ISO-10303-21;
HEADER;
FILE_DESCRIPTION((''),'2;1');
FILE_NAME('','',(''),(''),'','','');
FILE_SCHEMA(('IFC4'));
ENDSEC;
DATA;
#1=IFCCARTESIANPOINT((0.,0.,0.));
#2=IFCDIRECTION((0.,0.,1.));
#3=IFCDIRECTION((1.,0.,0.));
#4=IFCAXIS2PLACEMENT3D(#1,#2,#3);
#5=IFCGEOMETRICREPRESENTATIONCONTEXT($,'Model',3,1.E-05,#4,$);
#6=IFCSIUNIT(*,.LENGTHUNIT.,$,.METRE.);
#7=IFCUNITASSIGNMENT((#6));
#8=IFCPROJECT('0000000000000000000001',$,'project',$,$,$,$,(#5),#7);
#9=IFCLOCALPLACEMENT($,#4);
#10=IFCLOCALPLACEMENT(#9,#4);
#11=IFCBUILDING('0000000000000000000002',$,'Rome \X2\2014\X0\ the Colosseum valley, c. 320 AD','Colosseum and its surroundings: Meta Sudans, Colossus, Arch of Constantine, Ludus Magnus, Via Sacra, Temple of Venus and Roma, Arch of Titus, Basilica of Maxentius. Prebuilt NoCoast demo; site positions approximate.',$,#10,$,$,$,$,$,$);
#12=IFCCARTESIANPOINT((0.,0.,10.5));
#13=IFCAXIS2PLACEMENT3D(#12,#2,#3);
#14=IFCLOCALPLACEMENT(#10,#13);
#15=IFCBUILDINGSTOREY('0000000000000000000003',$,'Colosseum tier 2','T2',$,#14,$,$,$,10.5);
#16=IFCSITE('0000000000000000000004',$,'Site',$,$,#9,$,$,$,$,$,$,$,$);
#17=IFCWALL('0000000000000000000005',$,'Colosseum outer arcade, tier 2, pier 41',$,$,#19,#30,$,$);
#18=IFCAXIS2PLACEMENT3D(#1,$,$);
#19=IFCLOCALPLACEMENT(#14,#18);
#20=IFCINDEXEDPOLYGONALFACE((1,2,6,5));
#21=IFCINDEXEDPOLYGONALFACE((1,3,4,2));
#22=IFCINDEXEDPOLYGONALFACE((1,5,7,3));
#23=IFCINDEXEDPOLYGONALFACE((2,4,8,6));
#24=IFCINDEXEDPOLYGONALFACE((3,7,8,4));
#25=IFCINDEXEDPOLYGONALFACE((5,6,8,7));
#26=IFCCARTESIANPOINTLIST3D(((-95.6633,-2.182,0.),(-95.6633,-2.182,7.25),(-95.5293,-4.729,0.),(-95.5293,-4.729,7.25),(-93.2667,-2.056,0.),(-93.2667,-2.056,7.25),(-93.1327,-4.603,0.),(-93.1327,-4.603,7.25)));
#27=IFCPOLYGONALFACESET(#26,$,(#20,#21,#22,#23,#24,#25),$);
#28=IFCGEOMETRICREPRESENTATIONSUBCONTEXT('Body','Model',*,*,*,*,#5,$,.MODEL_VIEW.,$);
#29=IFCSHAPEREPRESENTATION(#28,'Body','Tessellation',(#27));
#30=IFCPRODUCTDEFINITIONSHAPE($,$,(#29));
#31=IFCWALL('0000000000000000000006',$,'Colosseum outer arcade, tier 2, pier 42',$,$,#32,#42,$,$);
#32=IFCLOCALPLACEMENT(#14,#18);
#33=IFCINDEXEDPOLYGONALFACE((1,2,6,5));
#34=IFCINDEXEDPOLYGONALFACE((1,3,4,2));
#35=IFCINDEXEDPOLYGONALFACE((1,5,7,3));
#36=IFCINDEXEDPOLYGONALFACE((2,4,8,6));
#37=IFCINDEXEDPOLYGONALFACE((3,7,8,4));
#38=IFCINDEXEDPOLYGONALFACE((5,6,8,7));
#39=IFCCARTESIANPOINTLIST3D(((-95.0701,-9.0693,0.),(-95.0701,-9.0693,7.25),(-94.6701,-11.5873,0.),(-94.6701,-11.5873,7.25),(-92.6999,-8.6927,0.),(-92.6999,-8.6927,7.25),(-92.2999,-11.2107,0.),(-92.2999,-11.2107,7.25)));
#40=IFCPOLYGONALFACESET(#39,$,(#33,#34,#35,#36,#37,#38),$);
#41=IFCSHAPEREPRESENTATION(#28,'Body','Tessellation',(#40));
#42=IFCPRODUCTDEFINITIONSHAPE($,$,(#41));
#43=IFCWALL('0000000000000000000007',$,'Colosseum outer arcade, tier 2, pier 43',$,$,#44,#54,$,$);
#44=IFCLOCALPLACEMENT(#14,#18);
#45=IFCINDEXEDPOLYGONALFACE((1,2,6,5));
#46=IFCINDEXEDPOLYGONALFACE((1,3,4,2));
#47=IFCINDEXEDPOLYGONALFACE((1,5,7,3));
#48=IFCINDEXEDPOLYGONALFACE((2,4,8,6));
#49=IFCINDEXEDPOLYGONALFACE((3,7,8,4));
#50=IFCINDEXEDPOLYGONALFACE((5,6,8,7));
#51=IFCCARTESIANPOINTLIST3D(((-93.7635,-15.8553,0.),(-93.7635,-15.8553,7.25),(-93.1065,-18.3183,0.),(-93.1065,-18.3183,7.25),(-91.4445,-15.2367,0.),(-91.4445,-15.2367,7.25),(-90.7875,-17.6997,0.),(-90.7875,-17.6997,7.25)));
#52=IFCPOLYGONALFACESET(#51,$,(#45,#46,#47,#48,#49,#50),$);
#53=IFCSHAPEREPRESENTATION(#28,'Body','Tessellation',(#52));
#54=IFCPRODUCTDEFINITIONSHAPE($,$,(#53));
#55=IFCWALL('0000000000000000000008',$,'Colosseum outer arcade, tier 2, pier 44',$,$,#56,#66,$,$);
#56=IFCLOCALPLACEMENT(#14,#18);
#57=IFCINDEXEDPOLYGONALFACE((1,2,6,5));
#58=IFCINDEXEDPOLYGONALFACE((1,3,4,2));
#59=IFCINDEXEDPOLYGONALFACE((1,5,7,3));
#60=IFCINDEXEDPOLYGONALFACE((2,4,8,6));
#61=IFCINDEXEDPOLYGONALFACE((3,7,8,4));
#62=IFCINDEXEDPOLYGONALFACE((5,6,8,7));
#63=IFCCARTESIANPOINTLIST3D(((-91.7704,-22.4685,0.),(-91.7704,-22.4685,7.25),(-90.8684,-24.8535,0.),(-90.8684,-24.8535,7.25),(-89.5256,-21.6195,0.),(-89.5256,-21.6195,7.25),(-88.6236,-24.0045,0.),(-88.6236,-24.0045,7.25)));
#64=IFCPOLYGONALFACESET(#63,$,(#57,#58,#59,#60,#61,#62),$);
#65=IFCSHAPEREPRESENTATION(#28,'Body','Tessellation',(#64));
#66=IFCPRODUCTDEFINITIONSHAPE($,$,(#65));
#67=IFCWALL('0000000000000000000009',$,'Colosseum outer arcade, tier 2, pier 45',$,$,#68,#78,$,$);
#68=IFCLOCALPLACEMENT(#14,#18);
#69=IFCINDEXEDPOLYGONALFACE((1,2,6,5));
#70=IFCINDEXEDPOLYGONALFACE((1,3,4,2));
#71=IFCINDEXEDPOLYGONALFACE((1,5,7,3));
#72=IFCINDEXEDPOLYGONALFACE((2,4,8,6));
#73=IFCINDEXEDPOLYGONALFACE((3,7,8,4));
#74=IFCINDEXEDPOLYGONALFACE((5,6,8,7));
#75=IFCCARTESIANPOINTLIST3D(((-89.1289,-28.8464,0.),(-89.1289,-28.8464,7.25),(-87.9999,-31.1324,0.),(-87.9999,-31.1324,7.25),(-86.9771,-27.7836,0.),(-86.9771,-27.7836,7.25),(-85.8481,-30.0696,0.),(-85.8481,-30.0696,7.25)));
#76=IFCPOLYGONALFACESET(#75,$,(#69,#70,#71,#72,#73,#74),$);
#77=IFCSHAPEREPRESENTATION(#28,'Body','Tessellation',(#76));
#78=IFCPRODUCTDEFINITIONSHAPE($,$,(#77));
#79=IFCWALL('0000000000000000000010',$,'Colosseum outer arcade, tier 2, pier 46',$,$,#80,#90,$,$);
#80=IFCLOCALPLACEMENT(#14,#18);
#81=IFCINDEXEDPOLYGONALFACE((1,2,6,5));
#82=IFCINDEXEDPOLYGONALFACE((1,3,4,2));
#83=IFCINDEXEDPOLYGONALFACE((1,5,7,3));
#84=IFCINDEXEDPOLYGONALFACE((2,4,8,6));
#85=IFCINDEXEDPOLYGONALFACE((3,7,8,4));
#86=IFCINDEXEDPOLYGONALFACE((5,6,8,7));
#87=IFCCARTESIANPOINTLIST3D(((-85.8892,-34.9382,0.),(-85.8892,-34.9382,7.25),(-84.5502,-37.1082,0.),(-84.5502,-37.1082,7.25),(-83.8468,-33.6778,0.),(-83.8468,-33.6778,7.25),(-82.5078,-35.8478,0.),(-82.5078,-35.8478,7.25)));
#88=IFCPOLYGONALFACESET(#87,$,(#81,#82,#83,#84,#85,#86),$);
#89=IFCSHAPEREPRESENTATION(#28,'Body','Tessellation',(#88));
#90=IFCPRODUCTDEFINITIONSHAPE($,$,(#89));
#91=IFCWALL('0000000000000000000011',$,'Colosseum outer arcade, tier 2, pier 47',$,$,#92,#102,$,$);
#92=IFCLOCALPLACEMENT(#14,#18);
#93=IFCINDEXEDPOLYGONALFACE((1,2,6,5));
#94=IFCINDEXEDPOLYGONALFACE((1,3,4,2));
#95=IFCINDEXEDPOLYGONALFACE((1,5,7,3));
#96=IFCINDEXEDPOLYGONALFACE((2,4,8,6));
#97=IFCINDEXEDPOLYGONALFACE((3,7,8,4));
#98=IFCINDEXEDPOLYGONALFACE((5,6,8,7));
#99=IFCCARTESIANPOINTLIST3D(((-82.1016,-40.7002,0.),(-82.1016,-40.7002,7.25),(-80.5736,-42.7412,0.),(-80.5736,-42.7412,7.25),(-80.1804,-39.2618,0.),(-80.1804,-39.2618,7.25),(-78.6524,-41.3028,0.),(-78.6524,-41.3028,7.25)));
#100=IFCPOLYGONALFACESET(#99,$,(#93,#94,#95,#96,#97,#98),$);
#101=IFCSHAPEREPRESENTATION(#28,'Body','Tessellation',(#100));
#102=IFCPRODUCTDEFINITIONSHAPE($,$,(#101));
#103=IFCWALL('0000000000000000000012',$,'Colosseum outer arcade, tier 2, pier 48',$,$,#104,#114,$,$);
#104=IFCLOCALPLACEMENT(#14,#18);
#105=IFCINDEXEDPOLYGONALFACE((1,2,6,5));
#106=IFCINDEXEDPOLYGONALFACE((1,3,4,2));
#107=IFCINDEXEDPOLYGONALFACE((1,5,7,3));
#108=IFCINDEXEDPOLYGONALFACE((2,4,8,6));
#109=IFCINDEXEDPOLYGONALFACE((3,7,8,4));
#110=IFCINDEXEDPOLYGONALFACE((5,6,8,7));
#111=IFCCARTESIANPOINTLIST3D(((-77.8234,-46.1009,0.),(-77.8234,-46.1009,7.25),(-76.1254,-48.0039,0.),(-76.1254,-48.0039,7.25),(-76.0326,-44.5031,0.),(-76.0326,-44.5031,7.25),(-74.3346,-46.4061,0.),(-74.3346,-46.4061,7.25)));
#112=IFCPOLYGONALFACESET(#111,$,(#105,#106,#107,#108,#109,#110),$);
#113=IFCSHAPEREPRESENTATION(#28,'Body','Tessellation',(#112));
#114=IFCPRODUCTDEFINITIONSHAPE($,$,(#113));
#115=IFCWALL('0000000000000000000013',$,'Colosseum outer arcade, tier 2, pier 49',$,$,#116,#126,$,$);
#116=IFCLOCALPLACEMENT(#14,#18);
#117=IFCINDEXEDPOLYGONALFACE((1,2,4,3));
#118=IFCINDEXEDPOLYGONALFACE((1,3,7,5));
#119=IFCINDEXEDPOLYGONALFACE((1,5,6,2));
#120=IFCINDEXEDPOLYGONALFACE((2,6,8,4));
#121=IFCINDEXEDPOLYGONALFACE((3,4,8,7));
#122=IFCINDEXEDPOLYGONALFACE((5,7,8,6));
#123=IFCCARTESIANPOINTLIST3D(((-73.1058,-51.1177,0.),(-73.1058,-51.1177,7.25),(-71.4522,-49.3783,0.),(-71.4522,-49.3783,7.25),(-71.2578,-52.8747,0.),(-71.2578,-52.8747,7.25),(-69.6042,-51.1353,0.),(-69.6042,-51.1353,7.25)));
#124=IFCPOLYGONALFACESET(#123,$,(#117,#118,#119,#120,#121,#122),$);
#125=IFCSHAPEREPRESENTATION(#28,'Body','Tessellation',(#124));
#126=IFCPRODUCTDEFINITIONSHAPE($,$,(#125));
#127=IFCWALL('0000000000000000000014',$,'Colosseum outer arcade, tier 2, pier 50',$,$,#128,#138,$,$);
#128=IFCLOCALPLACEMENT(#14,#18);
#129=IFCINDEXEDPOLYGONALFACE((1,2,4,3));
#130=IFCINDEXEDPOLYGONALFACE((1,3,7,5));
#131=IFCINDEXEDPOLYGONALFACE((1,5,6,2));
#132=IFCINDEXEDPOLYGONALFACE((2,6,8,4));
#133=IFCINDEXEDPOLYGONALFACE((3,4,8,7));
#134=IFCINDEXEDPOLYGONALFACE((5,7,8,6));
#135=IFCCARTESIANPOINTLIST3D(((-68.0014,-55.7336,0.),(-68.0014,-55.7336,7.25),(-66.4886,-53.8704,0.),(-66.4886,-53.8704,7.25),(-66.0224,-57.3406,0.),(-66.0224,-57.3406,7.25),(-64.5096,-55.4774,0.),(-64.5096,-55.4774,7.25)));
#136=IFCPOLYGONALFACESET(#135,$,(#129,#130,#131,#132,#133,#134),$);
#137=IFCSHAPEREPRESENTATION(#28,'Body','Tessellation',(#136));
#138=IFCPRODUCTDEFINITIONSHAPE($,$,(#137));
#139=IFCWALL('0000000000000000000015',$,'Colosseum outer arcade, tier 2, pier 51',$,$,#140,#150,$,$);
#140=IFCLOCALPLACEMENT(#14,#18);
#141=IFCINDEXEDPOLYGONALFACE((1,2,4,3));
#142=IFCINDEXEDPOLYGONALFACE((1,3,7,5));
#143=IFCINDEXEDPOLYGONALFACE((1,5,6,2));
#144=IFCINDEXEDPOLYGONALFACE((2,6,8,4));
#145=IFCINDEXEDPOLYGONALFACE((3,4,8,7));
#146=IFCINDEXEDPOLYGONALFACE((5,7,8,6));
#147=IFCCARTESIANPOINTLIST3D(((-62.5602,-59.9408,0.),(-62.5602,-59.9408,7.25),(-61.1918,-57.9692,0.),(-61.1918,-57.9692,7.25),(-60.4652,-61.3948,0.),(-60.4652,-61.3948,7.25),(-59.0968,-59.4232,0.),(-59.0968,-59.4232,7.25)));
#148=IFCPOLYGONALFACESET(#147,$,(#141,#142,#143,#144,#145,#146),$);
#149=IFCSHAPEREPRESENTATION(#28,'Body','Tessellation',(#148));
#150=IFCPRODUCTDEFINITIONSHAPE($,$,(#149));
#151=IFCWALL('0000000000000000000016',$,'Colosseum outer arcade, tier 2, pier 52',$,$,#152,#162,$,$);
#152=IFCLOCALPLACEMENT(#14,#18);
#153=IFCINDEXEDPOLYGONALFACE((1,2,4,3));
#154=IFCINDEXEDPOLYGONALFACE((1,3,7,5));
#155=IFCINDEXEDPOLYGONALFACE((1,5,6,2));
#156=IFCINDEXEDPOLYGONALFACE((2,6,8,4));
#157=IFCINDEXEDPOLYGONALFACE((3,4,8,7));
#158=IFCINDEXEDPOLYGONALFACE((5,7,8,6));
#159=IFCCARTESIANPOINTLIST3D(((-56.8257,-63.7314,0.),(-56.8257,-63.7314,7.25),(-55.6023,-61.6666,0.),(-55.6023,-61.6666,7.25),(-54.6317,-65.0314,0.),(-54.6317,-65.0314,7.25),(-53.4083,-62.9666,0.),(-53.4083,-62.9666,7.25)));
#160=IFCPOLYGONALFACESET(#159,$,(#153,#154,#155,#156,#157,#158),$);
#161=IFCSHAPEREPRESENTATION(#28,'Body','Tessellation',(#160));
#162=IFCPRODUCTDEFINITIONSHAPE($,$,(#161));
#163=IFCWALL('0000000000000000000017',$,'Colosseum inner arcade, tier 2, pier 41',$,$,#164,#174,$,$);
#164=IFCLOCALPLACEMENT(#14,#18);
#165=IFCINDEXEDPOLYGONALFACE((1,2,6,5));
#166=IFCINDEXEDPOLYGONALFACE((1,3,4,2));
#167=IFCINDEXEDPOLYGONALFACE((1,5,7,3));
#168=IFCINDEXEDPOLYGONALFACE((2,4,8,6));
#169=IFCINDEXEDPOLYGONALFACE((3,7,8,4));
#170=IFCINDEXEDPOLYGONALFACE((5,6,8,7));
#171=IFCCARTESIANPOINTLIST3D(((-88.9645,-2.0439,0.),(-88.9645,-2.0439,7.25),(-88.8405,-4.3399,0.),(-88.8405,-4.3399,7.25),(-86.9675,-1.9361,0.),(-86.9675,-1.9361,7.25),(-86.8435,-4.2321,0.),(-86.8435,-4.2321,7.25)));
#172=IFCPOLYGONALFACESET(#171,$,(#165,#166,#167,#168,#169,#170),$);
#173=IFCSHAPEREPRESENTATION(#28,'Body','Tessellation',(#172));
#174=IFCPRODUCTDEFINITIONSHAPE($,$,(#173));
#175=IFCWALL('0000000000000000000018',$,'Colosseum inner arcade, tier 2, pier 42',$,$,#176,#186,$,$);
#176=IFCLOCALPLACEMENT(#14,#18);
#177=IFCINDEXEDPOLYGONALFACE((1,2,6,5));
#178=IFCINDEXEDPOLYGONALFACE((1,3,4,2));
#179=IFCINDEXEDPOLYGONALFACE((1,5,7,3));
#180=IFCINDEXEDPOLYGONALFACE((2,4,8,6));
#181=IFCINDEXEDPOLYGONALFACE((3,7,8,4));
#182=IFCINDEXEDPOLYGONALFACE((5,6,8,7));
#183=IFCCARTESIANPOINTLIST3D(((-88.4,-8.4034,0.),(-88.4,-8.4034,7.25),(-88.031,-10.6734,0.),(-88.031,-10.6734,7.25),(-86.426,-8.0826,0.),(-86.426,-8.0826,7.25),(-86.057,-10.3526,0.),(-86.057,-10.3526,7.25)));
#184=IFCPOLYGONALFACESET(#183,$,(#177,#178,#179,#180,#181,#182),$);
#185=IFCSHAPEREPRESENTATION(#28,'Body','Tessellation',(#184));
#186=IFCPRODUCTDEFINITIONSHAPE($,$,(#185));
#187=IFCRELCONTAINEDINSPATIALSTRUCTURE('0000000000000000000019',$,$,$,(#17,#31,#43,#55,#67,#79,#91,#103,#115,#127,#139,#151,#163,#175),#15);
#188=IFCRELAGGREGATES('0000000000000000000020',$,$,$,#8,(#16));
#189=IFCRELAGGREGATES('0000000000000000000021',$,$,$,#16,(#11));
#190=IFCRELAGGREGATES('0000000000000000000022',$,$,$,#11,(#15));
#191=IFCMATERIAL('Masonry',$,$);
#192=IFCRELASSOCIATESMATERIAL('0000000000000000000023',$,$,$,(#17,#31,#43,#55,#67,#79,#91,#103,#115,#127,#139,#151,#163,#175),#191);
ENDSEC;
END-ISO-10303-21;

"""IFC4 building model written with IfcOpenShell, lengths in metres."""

from ifc_helpers import new_model, si_unit, frame, origin_with_axes, place, context, subcontext, project, spatial, indexed_curve, outline, extrude, material, element, save


model = new_model("IFC4")

# Units and contexts
model_context = context("Model", 3, precision=1e-05, world=origin_with_axes())
body_context = subcontext(model_context, "Body", "Model", "MODEL_VIEW")
ifc_project = project(units=[si_unit("LENGTHUNIT", "METRE")], contexts=[model_context])

# Site, building, storey
site_placement = place(None, origin_with_axes())
site = spatial("IfcSite", under=ifc_project, at=site_placement, Name="Site")
building_placement = place(site_placement, origin_with_axes())
building = spatial("IfcBuilding", under=site, at=building_placement, Name="Rome — the Colosseum valley, c. 320 AD", Description="Colosseum and its surroundings: Meta Sudans, Colossus, Arch of Constantine, Ludus Magnus, Via Sacra, Temple of Venus and Roma, Arch of Titus, Basilica of Maxentius. Prebuilt NoCoast demo; site positions approximate.")
storey_placement = place(building_placement, frame((0.0, 0.0, 10.5), z_axis=(0.0, 0.0, 1.0), x_axis=(1.0, 0.0, 0.0)))
storey = spatial("IfcBuildingStorey", under=building, at=storey_placement, Name="Colosseum tier 2", Description="T2", Elevation=10.5)

# Walls
ifc_material = material(Name="Masonry")
wall_1_placement = place(storey_placement, frame((-94.465, -2.119, 0.0), z_axis=(0.0, 0.0, 1.0), x_axis=(0.052538, -0.998619, 0.0)))
element("IfcWall", 1, at=wall_1_placement, inside=storey, material=ifc_material, Name="Colosseum outer arcade, tier 2, pier 41", context=body_context, shape_type="SweptSolid", body=[
    extrude(outline(indexed_curve([(0.0, 0.0), (0.0, 2.4), (2.5505, 2.4), (2.5505, 0.0), (0.0, 0.0)], self_intersect=False)), frame((0.0, -1.2, 0.0), z_axis=(0.0, 0.0, 1.0), x_axis=(1.0, 0.0, 0.0)), (0.0, 0.0, 1.0), 7.25),
])
wall_2_placement = place(storey_placement, frame((-93.885, -8.881, 0.0), z_axis=(0.0, 0.0, 1.0), x_axis=(0.156889, -0.987616, 0.0)))
element("IfcWall", 2, at=wall_2_placement, inside=storey, material=ifc_material, Name="Colosseum outer arcade, tier 2, pier 42", context=body_context, shape_type="SweptSolid", body=[
    extrude(outline(indexed_curve([(0.0, 0.0), (0.0, 2.4), (2.5496, 2.4), (2.5496, 0.0), (0.0, 0.0)], self_intersect=False)), frame((0.0, -1.2, 0.0), z_axis=(0.0, 0.0, 1.0), x_axis=(1.0, 0.0, 0.0)), (0.0, 0.0, 1.0), 7.25),
])
wall_3_placement = place(storey_placement, frame((-92.604, -15.546, 0.0), z_axis=(0.0, 0.0, 1.0), x_axis=(0.257736, -0.966215, 0.0)))
element("IfcWall", 3, at=wall_3_placement, inside=storey, material=ifc_material, Name="Colosseum outer arcade, tier 2, pier 43", context=body_context, shape_type="SweptSolid", body=[
    extrude(outline(indexed_curve([(0.0, 0.0), (0.0, 2.4), (2.5491, 2.4), (2.5491, 0.0), (0.0, 0.0)], self_intersect=False)), frame((0.0, -1.2, 0.0), z_axis=(0.0, 0.0, 1.0), x_axis=(1.0, 0.0, 0.0)), (0.0, 0.0, 1.0), 7.25),
])
wall_4_placement = place(storey_placement, frame((-90.648, -22.044, 0.0), z_axis=(0.0, 0.0, 1.0), x_axis=(0.353744, -0.935342, 0.0)))
element("IfcWall", 4, at=wall_4_placement, inside=storey, material=ifc_material, Name="Colosseum outer arcade, tier 2, pier 44", context=body_context, shape_type="SweptSolid", body=[
    extrude(outline(indexed_curve([(0.0, 0.0), (0.0, 2.4), (2.5499, 2.4), (2.5499, 0.0), (0.0, 0.0)], self_intersect=False)), frame((0.0, -1.2, 0.0), z_axis=(0.0, 0.0, 1.0), x_axis=(1.0, 0.0, 0.0)), (0.0, 0.0, 1.0), 7.25),
])
wall_5_placement = place(storey_placement, frame((-88.053, -28.315, 0.0), z_axis=(0.0, 0.0, 1.0), x_axis=(0.442815, -0.896613, 0.0)))
element("IfcWall", 5, at=wall_5_placement, inside=storey, material=ifc_material, Name="Colosseum outer arcade, tier 2, pier 45", context=body_context, shape_type="SweptSolid", body=[
    extrude(outline(indexed_curve([(0.0, 0.0), (0.0, 2.4), (2.5496, 2.4), (2.5496, 0.0), (0.0, 0.0)], self_intersect=False)), frame((0.0, -1.2, 0.0), z_axis=(0.0, 0.0, 1.0), x_axis=(1.0, 0.0, 0.0)), (0.0, 0.0, 1.0), 7.25),
])
wall_6_placement = place(storey_placement, frame((-84.868, -34.308, 0.0), z_axis=(0.0, 0.0, 1.0), x_axis=(0.525125, -0.851025, 0.0)))
element("IfcWall", 6, at=wall_6_placement, inside=storey, material=ifc_material, Name="Colosseum outer arcade, tier 2, pier 46", context=body_context, shape_type="SweptSolid", body=[
    extrude(outline(indexed_curve([(0.0, 0.0), (0.0, 2.4), (2.5499, 2.4), (2.5499, 0.0), (0.0, 0.0)], self_intersect=False)), frame((0.0, -1.2, 0.0), z_axis=(0.0, 0.0, 1.0), x_axis=(1.0, 0.0, 0.0)), (0.0, 0.0, 1.0), 7.25),
])
wall_7_placement = place(storey_placement, frame((-81.141, -39.981, 0.0), z_axis=(0.0, 0.0, 1.0), x_axis=(0.599309, -0.800517, 0.0)))
element("IfcWall", 7, at=wall_7_placement, inside=storey, material=ifc_material, Name="Colosseum outer arcade, tier 2, pier 47", context=body_context, shape_type="SweptSolid", body=[
    extrude(outline(indexed_curve([(0.0, 0.0), (0.0, 2.4), (2.5496, 2.4), (2.5496, 0.0), (0.0, 0.0)], self_intersect=False)), frame((0.0, -1.2, 0.0), z_axis=(0.0, 0.0, 1.0), x_axis=(1.0, 0.0, 0.0)), (0.0, 0.0, 1.0), 7.25),
])
wall_8_placement = place(storey_placement, frame((-76.928, -45.302, 0.0), z_axis=(0.0, 0.0, 1.0), x_axis=(0.665774, -0.746153, 0.0)))
element("IfcWall", 8, at=wall_8_placement, inside=storey, material=ifc_material, Name="Colosseum outer arcade, tier 2, pier 48", context=body_context, shape_type="SweptSolid", body=[
    extrude(outline(indexed_curve([(0.0, 0.0), (0.0, 2.4), (2.5504, 2.4), (2.5504, 0.0), (0.0, 0.0)], self_intersect=False)), frame((0.0, -1.2, 0.0), z_axis=(0.0, 0.0, 1.0), x_axis=(1.0, 0.0, 0.0)), (0.0, 0.0, 1.0), 7.25),
])
wall_9_placement = place(storey_placement, frame((-72.279, -50.248, 0.0), z_axis=(0.0, 0.0, 1.0), x_axis=(0.724725, -0.689038, 0.0)))
element("IfcWall", 9, at=wall_9_placement, inside=storey, material=ifc_material, Name="Colosseum outer arcade, tier 2, pier 49", context=body_context, shape_type="SweptSolid", body=[
    extrude(outline(indexed_curve([(0.0, 0.0), (0.0, 2.4), (2.5499, 2.4), (2.5499, 0.0), (0.0, 0.0)], self_intersect=False)), frame((0.0, -1.2, 0.0), z_axis=(0.0, 0.0, 1.0), x_axis=(1.0, 0.0, 0.0)), (0.0, 0.0, 1.0), 7.25),
])
wall_10_placement = place(storey_placement, frame((-67.245, -54.802, 0.0), z_axis=(0.0, 0.0, 1.0), x_axis=(0.776294, -0.630371, 0.0)))
element("IfcWall", 10, at=wall_10_placement, inside=storey, material=ifc_material, Name="Colosseum outer arcade, tier 2, pier 50", context=body_context, shape_type="SweptSolid", body=[
    extrude(outline(indexed_curve([(0.0, 0.0), (0.0, 2.4), (2.5493, 2.4), (2.5493, 0.0), (0.0, 0.0)], self_intersect=False)), frame((0.0, -1.2, 0.0), z_axis=(0.0, 0.0, 1.0), x_axis=(1.0, 0.0, 0.0)), (0.0, 0.0, 1.0), 7.25),
])
wall_11_placement = place(storey_placement, frame((-61.876, -58.955, 0.0), z_axis=(0.0, 0.0, 1.0), x_axis=(0.821528, -0.570168, 0.0)))
element("IfcWall", 11, at=wall_11_placement, inside=storey, material=ifc_material, Name="Colosseum outer arcade, tier 2, pier 51", context=body_context, shape_type="SweptSolid", body=[
    extrude(outline(indexed_curve([(0.0, 0.0), (0.0, 2.4), (2.5501, 2.4), (2.5501, 0.0), (0.0, 0.0)], self_intersect=False)), frame((0.0, -1.2, 0.0), z_axis=(0.0, 0.0, 1.0), x_axis=(1.0, 0.0, 0.0)), (0.0, 0.0, 1.0), 7.25),
])
wall_12_placement = place(storey_placement, frame((-56.214, -62.699, 0.0), z_axis=(0.0, 0.0, 1.0), x_axis=(0.860317, -0.509759, 0.0)))
element("IfcWall", 12, at=wall_12_placement, inside=storey, material=ifc_material, Name="Colosseum outer arcade, tier 2, pier 52", context=body_context, shape_type="SweptSolid", body=[
    extrude(outline(indexed_curve([(0.0, 0.0), (0.0, 2.4), (2.5502, 2.4), (2.5502, 0.0), (0.0, 0.0)], self_intersect=False)), frame((0.0, -1.2, 0.0), z_axis=(0.0, 0.0, 1.0), x_axis=(1.0, 0.0, 0.0)), (0.0, 0.0, 1.0), 7.25),
])
wall_13_placement = place(storey_placement, frame((-87.966, -1.99, 0.0), z_axis=(0.0, 0.0, 1.0), x_axis=(0.053928, -0.998545, 0.0)))
element("IfcWall", 13, at=wall_13_placement, inside=storey, material=ifc_material, Name="Colosseum inner arcade, tier 2, pier 41", context=body_context, shape_type="SweptSolid", body=[
    extrude(outline(indexed_curve([(0.0, 0.0), (0.0, 2.0), (2.2993, 2.0), (2.2993, 0.0), (0.0, 0.0)], self_intersect=False)), frame((0.0, -1.0, 0.0), z_axis=(0.0, 0.0, 1.0), x_axis=(1.0, 0.0, 0.0)), (0.0, 0.0, 1.0), 7.25),
])
wall_14_placement = place(storey_placement, frame((-87.413, -8.243, 0.0), z_axis=(0.0, 0.0, 1.0), x_axis=(0.160449, -0.987044, 0.0)))
element("IfcWall", 14, at=wall_14_placement, inside=storey, material=ifc_material, Name="Colosseum inner arcade, tier 2, pier 42", context=body_context, shape_type="SweptSolid", body=[
    extrude(outline(indexed_curve([(0.0, 0.0), (0.0, 2.0), (2.2998, 2.0), (2.2998, 0.0), (0.0, 0.0)], self_intersect=False)), frame((0.0, -1.0, 0.0), z_axis=(0.0, 0.0, 1.0), x_axis=(1.0, 0.0, 0.0)), (0.0, 0.0, 1.0), 7.25),
])

save(model, "model.ifc")
